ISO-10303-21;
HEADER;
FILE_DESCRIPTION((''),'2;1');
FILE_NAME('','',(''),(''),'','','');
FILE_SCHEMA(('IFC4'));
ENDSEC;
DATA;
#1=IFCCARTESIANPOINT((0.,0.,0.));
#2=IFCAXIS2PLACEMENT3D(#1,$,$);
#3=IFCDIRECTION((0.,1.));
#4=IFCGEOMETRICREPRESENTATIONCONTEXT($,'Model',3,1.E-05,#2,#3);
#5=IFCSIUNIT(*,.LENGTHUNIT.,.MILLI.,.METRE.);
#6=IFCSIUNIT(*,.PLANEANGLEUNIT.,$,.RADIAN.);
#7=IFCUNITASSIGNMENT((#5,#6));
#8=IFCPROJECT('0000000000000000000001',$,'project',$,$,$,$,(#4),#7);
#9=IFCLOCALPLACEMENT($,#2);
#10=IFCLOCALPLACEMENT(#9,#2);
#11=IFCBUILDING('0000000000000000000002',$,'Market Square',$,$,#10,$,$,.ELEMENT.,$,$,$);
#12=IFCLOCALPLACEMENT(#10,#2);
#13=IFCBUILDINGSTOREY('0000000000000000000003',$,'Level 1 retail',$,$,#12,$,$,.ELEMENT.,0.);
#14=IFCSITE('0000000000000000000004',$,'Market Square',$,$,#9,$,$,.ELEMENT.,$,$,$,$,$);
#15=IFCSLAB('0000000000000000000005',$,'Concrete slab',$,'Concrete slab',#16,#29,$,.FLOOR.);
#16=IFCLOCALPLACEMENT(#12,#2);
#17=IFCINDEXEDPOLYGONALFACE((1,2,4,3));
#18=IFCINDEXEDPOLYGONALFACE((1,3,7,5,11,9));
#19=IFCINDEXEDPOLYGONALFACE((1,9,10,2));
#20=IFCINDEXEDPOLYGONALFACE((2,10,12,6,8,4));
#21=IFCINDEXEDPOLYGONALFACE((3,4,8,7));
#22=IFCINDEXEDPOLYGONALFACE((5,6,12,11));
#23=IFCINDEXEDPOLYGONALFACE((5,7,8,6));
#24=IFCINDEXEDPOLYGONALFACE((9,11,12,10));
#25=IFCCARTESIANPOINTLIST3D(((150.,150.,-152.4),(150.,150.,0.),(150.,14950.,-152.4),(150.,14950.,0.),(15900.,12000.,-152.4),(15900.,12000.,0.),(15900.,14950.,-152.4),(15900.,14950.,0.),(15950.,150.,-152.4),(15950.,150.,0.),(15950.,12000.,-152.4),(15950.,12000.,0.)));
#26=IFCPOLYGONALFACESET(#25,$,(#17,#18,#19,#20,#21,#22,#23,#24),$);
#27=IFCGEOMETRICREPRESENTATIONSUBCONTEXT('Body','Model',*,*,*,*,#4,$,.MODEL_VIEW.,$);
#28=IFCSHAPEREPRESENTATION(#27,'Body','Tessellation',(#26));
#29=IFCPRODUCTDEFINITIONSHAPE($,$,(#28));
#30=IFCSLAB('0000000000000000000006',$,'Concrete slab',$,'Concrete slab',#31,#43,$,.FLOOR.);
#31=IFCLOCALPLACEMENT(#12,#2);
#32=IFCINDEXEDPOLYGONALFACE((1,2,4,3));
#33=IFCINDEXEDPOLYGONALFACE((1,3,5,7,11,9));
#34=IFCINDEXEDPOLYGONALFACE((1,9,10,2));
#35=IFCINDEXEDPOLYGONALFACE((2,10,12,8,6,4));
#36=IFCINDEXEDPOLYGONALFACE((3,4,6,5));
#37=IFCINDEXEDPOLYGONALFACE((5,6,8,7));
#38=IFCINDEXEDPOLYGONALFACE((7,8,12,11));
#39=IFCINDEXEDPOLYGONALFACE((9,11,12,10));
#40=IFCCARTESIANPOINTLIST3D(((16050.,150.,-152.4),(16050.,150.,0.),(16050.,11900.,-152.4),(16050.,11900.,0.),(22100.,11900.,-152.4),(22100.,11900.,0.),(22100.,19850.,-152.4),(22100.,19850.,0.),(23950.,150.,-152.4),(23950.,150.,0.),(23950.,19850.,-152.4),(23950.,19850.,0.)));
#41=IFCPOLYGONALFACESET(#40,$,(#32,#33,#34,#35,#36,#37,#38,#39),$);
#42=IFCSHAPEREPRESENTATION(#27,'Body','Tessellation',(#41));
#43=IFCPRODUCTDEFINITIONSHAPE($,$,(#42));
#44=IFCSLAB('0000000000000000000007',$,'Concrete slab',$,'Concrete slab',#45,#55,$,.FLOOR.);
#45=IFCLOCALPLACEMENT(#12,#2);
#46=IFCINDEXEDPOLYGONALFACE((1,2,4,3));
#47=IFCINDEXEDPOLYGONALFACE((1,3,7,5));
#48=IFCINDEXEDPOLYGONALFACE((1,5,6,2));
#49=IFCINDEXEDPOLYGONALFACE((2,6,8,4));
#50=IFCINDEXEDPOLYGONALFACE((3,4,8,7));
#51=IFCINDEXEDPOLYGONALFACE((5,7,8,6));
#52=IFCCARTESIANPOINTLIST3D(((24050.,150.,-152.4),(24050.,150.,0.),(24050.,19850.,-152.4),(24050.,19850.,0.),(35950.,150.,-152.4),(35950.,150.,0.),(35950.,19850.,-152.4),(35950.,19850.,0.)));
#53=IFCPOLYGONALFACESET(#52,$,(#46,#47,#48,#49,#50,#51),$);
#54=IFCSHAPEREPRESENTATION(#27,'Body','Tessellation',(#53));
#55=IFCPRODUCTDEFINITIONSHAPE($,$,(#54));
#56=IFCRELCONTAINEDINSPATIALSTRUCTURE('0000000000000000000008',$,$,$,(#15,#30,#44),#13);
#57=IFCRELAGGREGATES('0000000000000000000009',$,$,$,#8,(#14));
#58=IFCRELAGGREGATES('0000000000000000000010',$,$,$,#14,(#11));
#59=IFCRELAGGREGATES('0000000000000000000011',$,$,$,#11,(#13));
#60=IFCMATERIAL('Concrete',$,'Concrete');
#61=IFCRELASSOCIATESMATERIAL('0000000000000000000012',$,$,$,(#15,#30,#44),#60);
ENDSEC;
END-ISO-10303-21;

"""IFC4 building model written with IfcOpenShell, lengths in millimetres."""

from ifc_helpers import new_model, si_unit, direction, frame, origin, origin_with_axes, place, context, subcontext, project, spatial, polyline, outline, extrude, material, element, save


model = new_model("IFC4")

# Units and contexts
model_context = context("Model", 3, precision=1e-05, world=origin(), true_north=direction((0.0, 1.0)))
body_context = subcontext(model_context, "Body", "Model", "MODEL_VIEW")
ifc_project = project(units=[si_unit("LENGTHUNIT", "METRE", prefix="MILLI"), si_unit("PLANEANGLEUNIT", "RADIAN")], contexts=[model_context])

# Site, building, storey
site_placement = place(None, origin())
site = spatial("IfcSite", under=ifc_project, at=site_placement, Name="Market Square", CompositionType="ELEMENT")
building_placement = place(site_placement, origin())
building = spatial("IfcBuilding", under=site, at=building_placement, Name="Market Square", CompositionType="ELEMENT")
storey_placement = place(building_placement, origin())
storey = spatial("IfcBuildingStorey", under=building, at=storey_placement, Name="Level 1 retail", CompositionType="ELEMENT", Elevation=0.0)

# Slabs
ifc_material_1 = material(Name="Concrete", Category="Concrete")
slab_1_placement = place(storey_placement, origin_with_axes())
element("IfcSlab", 1, at=slab_1_placement, inside=storey, material=ifc_material_1, Name="Concrete slab", ObjectType="Concrete slab", PredefinedType="FLOOR", context=body_context, shape_type="SweptSolid", body=[
    extrude(outline(polyline([(150.0, 150.0), (15950.0, 150.0), (15950.0, 12000.0), (15900.0, 12000.0), (15900.0, 14950.0), (150.0, 14950.0), (150.0, 150.0)])), frame((0.0, 0.0, -152.4)), (0.0, 0.0, 1.0), 152.4),
])
slab_2_placement = place(storey_placement, origin_with_axes())
element("IfcSlab", 2, at=slab_2_placement, inside=storey, material=ifc_material_1, Name="Concrete slab", ObjectType="Concrete slab", PredefinedType="FLOOR", context=body_context, shape_type="SweptSolid", body=[
    extrude(outline(polyline([(16050.0, 150.0), (23950.0, 150.0), (23950.0, 19850.0), (22100.0, 19850.0), (22100.0, 11900.0), (16050.0, 11900.0), (16050.0, 150.0)])), frame((0.0, 0.0, -152.4)), (0.0, 0.0, 1.0), 152.4),
])
slab_3_placement = place(storey_placement, origin_with_axes())
element("IfcSlab", 3, at=slab_3_placement, inside=storey, material=ifc_material_1, Name="Concrete slab", ObjectType="Concrete slab", PredefinedType="FLOOR", context=body_context, shape_type="SweptSolid", body=[
    extrude(outline(polyline([(24050.0, 150.0), (35950.0, 150.0), (35950.0, 19850.0), (24050.0, 19850.0), (24050.0, 150.0)])), frame((0.0, 0.0, -152.4)), (0.0, 0.0, 1.0), 152.4),
])

save(model, "model.ifc")
